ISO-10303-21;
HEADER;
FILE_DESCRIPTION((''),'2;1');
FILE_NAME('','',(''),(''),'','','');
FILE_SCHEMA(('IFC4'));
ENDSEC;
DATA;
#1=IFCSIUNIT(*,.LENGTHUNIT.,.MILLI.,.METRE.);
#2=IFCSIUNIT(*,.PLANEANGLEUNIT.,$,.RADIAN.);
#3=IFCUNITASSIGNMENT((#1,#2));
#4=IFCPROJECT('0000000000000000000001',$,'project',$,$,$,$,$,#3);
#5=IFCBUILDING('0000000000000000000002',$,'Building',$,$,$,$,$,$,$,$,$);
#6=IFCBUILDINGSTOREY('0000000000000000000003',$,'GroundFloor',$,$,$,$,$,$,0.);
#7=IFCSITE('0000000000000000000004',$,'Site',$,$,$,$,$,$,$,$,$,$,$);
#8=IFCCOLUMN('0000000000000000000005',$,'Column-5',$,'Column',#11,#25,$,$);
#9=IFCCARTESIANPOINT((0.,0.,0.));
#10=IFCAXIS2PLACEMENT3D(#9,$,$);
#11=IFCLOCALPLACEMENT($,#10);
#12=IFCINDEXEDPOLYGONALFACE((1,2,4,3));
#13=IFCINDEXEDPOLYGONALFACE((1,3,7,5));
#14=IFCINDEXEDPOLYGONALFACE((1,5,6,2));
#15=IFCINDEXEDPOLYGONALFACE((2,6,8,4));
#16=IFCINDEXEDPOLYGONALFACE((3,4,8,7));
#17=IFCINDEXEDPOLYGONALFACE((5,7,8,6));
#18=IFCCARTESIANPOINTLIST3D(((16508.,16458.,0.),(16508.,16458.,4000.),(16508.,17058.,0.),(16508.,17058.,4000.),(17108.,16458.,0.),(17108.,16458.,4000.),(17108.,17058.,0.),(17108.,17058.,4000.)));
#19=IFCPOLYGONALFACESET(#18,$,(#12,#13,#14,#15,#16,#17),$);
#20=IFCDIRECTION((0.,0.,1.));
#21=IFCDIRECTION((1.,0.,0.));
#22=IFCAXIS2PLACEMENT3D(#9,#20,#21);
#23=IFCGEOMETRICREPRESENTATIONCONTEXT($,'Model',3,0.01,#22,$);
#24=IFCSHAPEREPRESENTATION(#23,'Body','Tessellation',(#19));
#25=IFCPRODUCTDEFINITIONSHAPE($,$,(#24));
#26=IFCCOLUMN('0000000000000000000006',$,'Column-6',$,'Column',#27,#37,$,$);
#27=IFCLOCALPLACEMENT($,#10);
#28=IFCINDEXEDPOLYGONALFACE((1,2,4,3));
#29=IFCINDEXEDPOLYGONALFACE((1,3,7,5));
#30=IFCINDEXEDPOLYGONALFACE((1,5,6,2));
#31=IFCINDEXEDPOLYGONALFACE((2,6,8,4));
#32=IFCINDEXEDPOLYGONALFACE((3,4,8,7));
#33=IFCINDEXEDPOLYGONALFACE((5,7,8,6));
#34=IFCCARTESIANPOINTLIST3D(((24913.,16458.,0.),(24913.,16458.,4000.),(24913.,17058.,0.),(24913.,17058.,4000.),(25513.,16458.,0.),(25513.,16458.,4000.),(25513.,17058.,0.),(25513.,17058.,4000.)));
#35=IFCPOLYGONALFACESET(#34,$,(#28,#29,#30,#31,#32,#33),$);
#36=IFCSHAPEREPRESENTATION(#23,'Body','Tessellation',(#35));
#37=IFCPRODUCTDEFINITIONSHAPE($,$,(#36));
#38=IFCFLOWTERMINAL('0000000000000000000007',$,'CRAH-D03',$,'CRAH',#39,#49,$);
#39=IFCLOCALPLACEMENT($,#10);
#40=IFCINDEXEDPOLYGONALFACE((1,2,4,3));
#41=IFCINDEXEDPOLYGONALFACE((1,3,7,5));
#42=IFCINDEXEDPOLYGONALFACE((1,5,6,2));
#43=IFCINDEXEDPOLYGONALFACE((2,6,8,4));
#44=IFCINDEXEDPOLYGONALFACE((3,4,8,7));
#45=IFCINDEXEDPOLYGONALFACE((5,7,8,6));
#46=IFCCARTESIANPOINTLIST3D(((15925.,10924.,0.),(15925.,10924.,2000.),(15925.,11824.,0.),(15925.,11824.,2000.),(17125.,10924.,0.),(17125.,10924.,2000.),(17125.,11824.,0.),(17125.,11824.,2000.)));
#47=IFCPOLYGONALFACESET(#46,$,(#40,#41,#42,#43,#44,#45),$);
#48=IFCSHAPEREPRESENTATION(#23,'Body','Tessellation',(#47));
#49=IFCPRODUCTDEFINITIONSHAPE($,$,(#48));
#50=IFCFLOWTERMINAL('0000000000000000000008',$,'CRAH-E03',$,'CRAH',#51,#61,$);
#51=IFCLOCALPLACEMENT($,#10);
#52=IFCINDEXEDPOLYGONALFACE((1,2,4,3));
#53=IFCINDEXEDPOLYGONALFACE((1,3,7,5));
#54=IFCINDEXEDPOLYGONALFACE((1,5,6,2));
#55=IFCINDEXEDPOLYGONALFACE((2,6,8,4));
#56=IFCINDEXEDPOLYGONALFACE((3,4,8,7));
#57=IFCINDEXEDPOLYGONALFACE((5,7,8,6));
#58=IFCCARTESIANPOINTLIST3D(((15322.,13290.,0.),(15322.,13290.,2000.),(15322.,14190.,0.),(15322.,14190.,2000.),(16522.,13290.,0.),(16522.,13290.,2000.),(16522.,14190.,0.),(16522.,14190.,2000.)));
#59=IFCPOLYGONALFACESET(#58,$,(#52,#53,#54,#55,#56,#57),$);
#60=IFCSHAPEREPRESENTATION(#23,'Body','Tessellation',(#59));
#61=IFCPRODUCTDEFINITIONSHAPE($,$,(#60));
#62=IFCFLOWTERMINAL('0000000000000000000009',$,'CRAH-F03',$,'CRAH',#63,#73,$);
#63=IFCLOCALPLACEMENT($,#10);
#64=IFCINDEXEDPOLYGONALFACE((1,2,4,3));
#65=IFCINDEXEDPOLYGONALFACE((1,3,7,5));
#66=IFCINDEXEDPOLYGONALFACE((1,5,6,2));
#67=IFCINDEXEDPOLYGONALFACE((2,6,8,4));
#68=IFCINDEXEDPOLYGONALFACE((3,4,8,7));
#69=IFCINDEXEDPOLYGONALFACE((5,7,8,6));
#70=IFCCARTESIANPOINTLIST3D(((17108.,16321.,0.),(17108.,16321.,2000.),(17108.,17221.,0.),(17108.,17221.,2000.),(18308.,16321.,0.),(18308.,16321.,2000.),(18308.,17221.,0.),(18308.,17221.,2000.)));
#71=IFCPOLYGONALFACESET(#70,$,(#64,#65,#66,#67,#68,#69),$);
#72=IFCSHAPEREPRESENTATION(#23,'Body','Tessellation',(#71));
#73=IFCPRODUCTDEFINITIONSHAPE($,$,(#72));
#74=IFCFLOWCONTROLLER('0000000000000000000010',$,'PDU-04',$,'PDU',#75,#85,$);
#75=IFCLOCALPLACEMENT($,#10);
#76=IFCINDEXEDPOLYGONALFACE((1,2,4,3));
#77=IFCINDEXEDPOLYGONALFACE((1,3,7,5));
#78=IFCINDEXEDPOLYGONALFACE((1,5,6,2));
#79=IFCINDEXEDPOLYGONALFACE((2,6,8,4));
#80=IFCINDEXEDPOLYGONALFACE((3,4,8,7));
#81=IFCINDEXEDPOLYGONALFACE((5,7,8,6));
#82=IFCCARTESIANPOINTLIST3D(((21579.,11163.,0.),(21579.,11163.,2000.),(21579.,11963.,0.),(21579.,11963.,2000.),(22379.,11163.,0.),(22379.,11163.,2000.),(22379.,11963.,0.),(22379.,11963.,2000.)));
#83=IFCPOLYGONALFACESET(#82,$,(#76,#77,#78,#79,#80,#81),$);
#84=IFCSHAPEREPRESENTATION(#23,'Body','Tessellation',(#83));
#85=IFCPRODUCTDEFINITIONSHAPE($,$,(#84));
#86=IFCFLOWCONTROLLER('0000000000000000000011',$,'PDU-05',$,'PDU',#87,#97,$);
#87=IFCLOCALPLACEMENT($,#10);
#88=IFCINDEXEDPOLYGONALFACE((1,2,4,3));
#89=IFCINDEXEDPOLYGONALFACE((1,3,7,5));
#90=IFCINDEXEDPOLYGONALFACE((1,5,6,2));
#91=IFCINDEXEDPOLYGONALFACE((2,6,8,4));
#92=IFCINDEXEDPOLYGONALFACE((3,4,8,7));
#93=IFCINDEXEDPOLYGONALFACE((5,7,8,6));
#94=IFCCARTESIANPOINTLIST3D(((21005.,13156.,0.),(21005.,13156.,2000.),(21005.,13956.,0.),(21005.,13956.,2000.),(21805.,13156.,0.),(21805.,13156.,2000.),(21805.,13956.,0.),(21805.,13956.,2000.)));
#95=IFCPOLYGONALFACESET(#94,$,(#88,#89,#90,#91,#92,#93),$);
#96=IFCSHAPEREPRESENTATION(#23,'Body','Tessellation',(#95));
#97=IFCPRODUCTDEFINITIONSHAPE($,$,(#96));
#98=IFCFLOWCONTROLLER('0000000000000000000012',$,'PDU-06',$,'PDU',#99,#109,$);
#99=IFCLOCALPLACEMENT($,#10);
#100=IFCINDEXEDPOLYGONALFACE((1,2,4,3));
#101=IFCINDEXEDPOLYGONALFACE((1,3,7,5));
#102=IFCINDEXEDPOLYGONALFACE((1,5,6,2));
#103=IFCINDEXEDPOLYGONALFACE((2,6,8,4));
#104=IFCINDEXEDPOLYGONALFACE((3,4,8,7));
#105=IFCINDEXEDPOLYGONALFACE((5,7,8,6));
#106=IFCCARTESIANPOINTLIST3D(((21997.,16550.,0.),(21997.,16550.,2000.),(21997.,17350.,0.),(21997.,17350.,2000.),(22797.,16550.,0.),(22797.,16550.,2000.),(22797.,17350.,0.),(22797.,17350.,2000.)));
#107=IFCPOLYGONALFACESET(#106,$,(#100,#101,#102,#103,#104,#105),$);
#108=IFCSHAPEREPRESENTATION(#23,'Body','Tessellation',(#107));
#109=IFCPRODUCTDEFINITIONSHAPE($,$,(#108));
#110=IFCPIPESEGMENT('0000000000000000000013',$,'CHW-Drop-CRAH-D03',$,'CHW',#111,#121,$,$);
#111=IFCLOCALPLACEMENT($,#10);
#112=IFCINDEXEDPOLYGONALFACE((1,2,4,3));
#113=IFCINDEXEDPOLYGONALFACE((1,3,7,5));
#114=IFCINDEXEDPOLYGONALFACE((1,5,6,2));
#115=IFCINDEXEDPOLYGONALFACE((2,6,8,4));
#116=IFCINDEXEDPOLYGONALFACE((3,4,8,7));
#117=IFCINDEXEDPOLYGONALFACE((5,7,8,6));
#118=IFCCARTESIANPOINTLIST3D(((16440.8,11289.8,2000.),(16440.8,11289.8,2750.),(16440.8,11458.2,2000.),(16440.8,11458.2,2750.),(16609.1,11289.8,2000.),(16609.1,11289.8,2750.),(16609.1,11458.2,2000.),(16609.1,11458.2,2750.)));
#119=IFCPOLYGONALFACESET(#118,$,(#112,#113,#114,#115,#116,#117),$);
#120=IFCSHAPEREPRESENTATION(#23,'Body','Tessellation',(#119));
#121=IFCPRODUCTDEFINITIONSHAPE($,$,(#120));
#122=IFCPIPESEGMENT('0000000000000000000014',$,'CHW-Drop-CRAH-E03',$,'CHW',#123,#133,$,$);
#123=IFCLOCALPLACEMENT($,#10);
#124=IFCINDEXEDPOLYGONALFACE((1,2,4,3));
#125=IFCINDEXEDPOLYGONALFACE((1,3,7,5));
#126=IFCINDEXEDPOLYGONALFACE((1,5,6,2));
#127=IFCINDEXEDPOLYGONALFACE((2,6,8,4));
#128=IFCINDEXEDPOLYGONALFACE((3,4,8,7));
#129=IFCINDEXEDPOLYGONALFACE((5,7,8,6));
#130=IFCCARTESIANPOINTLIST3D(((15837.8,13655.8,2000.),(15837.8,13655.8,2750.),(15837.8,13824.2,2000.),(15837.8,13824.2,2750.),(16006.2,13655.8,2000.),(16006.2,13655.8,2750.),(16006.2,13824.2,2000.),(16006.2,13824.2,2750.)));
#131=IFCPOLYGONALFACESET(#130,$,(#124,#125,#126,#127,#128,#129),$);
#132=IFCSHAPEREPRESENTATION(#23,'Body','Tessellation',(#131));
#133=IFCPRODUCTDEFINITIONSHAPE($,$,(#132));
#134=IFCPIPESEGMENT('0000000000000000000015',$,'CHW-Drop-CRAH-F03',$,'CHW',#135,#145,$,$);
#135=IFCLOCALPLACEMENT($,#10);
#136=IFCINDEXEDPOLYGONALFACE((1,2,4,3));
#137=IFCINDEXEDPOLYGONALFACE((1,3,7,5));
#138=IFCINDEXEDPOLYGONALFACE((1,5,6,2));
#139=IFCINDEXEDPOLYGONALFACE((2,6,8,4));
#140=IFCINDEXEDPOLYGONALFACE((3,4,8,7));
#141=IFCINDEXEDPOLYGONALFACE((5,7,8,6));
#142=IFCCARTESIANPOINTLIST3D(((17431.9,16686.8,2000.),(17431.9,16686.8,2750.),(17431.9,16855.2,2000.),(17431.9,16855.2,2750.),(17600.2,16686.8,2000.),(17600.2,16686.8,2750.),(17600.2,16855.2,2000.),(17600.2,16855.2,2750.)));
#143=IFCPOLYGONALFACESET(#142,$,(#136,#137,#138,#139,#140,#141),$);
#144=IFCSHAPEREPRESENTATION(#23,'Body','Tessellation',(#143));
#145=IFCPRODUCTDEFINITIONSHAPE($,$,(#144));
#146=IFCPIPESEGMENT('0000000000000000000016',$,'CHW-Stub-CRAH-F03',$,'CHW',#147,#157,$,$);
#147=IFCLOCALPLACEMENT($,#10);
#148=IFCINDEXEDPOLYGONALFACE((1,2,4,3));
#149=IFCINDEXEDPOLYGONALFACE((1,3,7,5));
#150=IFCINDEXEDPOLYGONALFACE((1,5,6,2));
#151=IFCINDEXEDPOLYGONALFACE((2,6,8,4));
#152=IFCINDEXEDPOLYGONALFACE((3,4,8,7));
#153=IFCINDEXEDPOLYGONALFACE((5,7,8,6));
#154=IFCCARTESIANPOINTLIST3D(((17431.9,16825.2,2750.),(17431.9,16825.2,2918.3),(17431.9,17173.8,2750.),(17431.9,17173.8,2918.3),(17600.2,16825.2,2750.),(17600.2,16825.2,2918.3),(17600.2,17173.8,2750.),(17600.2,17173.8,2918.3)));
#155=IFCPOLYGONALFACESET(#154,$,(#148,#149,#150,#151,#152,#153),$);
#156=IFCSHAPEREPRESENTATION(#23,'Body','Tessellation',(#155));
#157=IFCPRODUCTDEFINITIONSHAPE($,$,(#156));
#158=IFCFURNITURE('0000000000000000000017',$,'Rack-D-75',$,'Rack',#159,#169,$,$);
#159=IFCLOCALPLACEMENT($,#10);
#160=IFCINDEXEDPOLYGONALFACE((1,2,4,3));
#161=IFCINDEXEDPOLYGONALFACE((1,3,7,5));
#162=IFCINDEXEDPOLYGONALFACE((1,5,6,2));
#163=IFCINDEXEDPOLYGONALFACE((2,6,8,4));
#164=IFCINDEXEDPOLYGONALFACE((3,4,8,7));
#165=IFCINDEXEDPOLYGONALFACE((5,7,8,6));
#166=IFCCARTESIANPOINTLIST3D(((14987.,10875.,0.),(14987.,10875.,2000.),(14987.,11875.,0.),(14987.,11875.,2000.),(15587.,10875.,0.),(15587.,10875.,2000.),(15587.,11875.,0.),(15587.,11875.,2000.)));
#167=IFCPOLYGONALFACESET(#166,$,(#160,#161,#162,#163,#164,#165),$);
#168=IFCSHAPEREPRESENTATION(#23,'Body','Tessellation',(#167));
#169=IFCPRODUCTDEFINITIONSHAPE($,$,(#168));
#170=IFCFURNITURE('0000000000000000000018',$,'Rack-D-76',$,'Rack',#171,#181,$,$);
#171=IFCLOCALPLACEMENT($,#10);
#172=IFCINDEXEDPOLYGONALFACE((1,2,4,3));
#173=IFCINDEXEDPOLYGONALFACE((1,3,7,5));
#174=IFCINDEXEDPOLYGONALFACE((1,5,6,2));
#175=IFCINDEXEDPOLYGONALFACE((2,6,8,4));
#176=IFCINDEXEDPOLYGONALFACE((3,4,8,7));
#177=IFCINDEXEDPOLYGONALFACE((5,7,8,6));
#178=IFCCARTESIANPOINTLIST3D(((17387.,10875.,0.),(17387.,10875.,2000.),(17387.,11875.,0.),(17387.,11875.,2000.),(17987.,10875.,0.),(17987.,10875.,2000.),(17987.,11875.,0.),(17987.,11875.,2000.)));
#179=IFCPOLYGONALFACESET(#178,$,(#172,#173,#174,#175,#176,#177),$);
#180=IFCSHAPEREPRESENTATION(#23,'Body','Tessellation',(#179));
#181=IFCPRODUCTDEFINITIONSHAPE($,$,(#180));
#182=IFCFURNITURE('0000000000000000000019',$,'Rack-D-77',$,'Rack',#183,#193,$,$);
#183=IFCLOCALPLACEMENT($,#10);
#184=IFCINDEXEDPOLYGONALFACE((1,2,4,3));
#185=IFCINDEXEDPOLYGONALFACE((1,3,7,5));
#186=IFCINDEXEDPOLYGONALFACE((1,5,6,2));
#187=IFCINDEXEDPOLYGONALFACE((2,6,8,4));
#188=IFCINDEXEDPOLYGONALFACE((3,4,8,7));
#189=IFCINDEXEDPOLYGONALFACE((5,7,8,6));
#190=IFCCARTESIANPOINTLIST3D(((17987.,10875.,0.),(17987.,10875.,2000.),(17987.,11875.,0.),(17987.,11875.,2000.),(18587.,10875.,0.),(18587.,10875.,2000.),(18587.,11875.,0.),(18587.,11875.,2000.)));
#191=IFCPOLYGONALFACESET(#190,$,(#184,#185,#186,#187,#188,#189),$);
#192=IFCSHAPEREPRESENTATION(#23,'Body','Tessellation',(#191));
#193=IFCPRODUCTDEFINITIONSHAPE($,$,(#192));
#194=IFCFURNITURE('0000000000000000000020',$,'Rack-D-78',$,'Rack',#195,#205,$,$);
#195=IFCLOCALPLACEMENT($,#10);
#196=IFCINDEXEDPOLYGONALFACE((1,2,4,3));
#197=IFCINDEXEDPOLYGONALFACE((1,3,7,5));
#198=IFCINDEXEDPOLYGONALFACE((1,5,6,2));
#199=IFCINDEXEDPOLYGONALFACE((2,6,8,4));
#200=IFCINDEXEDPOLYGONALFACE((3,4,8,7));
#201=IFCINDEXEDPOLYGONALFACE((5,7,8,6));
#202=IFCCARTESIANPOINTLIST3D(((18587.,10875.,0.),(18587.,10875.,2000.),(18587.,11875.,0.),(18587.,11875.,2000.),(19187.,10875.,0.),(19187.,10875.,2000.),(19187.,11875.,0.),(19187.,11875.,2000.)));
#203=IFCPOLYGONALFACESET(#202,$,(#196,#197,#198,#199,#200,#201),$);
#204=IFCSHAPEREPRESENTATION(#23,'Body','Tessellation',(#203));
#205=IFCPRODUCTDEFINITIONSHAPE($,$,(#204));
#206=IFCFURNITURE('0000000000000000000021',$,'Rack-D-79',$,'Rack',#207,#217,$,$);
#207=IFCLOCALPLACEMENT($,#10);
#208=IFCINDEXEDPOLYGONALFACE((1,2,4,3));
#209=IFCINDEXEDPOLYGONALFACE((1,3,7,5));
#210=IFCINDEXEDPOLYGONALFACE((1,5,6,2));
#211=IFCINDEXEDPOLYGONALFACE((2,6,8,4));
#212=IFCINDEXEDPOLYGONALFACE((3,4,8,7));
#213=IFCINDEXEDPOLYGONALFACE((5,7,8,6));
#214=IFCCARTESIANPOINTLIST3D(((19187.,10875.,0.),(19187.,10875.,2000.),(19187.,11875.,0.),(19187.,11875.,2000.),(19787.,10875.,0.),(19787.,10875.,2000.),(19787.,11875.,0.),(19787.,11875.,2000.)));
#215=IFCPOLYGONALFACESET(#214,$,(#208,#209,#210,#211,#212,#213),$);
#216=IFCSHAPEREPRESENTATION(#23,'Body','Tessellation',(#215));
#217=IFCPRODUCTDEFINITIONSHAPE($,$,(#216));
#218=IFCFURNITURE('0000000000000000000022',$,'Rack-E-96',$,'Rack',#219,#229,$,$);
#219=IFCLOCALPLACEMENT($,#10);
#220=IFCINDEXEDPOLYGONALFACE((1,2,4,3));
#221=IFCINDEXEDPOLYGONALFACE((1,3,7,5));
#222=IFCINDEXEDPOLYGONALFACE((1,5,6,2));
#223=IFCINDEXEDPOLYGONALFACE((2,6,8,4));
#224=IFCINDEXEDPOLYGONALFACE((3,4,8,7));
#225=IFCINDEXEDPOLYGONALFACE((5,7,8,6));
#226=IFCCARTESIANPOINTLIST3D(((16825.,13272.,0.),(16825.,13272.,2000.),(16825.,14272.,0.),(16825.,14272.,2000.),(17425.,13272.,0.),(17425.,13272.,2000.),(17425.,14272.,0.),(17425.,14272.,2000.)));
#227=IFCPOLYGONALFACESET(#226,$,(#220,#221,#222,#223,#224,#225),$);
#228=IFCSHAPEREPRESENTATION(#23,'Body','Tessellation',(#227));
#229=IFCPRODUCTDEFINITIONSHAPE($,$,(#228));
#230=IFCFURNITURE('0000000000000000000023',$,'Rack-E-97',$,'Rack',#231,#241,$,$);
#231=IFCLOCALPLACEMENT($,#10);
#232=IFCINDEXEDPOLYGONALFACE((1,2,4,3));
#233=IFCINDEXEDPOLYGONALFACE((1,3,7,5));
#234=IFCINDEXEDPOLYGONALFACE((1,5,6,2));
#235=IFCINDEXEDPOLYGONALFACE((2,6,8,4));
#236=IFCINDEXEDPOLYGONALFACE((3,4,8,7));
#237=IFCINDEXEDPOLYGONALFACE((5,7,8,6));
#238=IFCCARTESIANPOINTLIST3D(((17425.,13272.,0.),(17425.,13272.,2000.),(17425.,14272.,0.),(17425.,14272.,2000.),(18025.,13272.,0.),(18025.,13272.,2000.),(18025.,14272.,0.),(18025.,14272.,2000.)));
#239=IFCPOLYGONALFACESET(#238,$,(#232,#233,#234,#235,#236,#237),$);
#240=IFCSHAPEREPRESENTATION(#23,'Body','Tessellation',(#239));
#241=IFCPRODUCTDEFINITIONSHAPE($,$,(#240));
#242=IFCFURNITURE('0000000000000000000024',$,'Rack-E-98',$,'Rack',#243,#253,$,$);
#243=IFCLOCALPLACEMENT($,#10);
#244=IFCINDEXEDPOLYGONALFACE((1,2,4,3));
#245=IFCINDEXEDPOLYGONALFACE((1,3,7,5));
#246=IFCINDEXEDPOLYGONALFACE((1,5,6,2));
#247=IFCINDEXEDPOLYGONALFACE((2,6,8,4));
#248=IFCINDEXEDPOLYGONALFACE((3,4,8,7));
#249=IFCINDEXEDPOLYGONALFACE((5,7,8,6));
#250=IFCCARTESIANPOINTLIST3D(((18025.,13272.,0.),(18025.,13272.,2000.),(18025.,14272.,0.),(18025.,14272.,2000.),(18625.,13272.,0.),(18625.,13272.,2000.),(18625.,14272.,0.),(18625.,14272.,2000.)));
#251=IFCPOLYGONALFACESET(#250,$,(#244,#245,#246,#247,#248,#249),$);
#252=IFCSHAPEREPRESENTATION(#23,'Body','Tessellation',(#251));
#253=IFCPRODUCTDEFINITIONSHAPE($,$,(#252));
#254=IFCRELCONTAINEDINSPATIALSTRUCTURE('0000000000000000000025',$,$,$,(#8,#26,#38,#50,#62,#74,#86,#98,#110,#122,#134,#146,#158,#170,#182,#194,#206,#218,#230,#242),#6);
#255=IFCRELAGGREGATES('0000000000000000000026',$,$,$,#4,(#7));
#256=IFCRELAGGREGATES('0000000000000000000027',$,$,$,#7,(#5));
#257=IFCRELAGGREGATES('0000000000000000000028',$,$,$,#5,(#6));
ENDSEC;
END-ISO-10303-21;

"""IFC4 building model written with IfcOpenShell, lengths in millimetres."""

from ifc_helpers import new_model, si_unit, frame, origin, origin_with_axes, origin_2d, place, context, project, spatial, rectangle, extrude, element, save


model = new_model("IFC4")

# Units and contexts
model_context = context("Model", 3, precision=0.01, world=origin_with_axes())
ifc_project = project(units=[si_unit("LENGTHUNIT", "METRE", prefix="MILLI"), si_unit("PLANEANGLEUNIT", "RADIAN")])

# Site, building, storey
site = spatial("IfcSite", under=ifc_project, Name="Site")
building = spatial("IfcBuilding", under=site, Name="Building")
storey = spatial("IfcBuildingStorey", under=building, Name="GroundFloor", Elevation=0.0)

# Columns
for number, where, z_axis, x_axis, name in (
    (1, (16808.0, 16758.0, 0.0), (0.0, 0.0, 1.0), (1.0, 0.0, 0.0), "Column-5"),
    (2, (25213.0, 16758.0, 0.0), (0.0, 0.0, 1.0), (1.0, 0.0, 0.0), "Column-6"),
):
    element("IfcColumn", number, at=place(None, frame(where, z_axis=z_axis, x_axis=x_axis)), inside=storey, Name=name, ObjectType="Column", context=model_context, shape_type="SweptSolid", body=[
        extrude(rectangle(XDim=600.0, YDim=600.0, at=origin_2d()), origin(), (0.0, 0.0, 1.0), 4000.0),
    ])

# Flow terminals
for number, where, z_axis, x_axis, name in (
    (3, (16525.0, 11374.0, 0.0), (0.0, 0.0, 1.0), (1.0, 0.0, 0.0), "CRAH-D03"),
    (4, (15922.0, 13740.0, 0.0), (0.0, 0.0, 1.0), (1.0, 0.0, 0.0), "CRAH-E03"),
    (5, (17708.0, 16771.0, 0.0), (0.0, 0.0, 1.0), (1.0, 0.0, 0.0), "CRAH-F03"),
):
    element("IfcFlowTerminal", number, at=place(None, frame(where, z_axis=z_axis, x_axis=x_axis)), inside=storey, Name=name, ObjectType="CRAH", context=model_context, shape_type="SweptSolid", body=[
        extrude(rectangle(XDim=1200.0, YDim=900.0, at=origin_2d()), origin(), (0.0, 0.0, 1.0), 2000.0),
    ])

# Flow controllers
for number, where, z_axis, x_axis, name in (
    (6, (21979.0, 11563.0, 0.0), (0.0, 0.0, 1.0), (1.0, 0.0, 0.0), "PDU-04"),
    (7, (21405.0, 13556.0, 0.0), (0.0, 0.0, 1.0), (1.0, 0.0, 0.0), "PDU-05"),
    (8, (22397.0, 16950.0, 0.0), (0.0, 0.0, 1.0), (1.0, 0.0, 0.0), "PDU-06"),
):
    element("IfcFlowController", number, at=place(None, frame(where, z_axis=z_axis, x_axis=x_axis)), inside=storey, Name=name, ObjectType="PDU", context=model_context, shape_type="SweptSolid", body=[
        extrude(rectangle(XDim=800.0, YDim=800.0, at=origin_2d()), origin(), (0.0, 0.0, 1.0), 2000.0),
    ])

# Pipe segments
for number, where, z_axis, x_axis, name in (
    (9, (16525.0, 11374.0, 2000.0), (0.0, 0.0, 1.0), (1.0, 0.0, 0.0), "CHW-Drop-CRAH-D03"),
    (10, (15922.0, 13740.0, 2000.0), (0.0, 0.0, 1.0), (1.0, 0.0, 0.0), "CHW-Drop-CRAH-E03"),
    (11, (17516.0, 16771.0, 2000.0), (0.0, 0.0, 1.0), (1.0, 0.0, 0.0), "CHW-Drop-CRAH-F03"),
):
    element("IfcPipeSegment", number, at=place(None, frame(where, z_axis=z_axis, x_axis=x_axis)), inside=storey, Name=name, ObjectType="CHW", context=model_context, shape_type="SweptSolid", body=[
        extrude(rectangle(XDim=168.3, YDim=168.3, at=origin_2d()), origin(), (0.0, 0.0, 1.0), 750.0),
    ])
pipe_segment_placement = place(None, frame((17516.0, 16999.5, 2750.0), z_axis=(0.0, 0.0, 1.0), x_axis=(1.0, 0.0, 0.0)))
element("IfcPipeSegment", 12, at=pipe_segment_placement, inside=storey, Name="CHW-Stub-CRAH-F03", ObjectType="CHW", context=model_context, shape_type="SweptSolid", body=[
    extrude(rectangle(XDim=168.3, YDim=348.7, at=origin_2d()), origin(), (0.0, 0.0, 1.0), 168.3),
])

# Furniture
for number, where, z_axis, x_axis, name in (
    (13, (15287.0, 11375.0, 0.0), (0.0, 0.0, 1.0), (1.0, 0.0, 0.0), "Rack-D-75"),
    (14, (17687.0, 11375.0, 0.0), (0.0, 0.0, 1.0), (1.0, 0.0, 0.0), "Rack-D-76"),
    (15, (18287.0, 11375.0, 0.0), (0.0, 0.0, 1.0), (1.0, 0.0, 0.0), "Rack-D-77"),
    (16, (18887.0, 11375.0, 0.0), (0.0, 0.0, 1.0), (1.0, 0.0, 0.0), "Rack-D-78"),
    (17, (19487.0, 11375.0, 0.0), (0.0, 0.0, 1.0), (1.0, 0.0, 0.0), "Rack-D-79"),
    (18, (17125.0, 13772.0, 0.0), (0.0, 0.0, 1.0), (1.0, 0.0, 0.0), "Rack-E-96"),
    (19, (17725.0, 13772.0, 0.0), (0.0, 0.0, 1.0), (1.0, 0.0, 0.0), "Rack-E-97"),
    (20, (18325.0, 13772.0, 0.0), (0.0, 0.0, 1.0), (1.0, 0.0, 0.0), "Rack-E-98"),
):
    element("IfcFurniture", number, at=place(None, frame(where, z_axis=z_axis, x_axis=x_axis)), inside=storey, Name=name, ObjectType="Rack", context=model_context, shape_type="SweptSolid", body=[
        extrude(rectangle(XDim=600.0, YDim=1000.0, at=origin_2d()), origin(), (0.0, 0.0, 1.0), 2000.0),
    ])

save(model, "model.ifc")
